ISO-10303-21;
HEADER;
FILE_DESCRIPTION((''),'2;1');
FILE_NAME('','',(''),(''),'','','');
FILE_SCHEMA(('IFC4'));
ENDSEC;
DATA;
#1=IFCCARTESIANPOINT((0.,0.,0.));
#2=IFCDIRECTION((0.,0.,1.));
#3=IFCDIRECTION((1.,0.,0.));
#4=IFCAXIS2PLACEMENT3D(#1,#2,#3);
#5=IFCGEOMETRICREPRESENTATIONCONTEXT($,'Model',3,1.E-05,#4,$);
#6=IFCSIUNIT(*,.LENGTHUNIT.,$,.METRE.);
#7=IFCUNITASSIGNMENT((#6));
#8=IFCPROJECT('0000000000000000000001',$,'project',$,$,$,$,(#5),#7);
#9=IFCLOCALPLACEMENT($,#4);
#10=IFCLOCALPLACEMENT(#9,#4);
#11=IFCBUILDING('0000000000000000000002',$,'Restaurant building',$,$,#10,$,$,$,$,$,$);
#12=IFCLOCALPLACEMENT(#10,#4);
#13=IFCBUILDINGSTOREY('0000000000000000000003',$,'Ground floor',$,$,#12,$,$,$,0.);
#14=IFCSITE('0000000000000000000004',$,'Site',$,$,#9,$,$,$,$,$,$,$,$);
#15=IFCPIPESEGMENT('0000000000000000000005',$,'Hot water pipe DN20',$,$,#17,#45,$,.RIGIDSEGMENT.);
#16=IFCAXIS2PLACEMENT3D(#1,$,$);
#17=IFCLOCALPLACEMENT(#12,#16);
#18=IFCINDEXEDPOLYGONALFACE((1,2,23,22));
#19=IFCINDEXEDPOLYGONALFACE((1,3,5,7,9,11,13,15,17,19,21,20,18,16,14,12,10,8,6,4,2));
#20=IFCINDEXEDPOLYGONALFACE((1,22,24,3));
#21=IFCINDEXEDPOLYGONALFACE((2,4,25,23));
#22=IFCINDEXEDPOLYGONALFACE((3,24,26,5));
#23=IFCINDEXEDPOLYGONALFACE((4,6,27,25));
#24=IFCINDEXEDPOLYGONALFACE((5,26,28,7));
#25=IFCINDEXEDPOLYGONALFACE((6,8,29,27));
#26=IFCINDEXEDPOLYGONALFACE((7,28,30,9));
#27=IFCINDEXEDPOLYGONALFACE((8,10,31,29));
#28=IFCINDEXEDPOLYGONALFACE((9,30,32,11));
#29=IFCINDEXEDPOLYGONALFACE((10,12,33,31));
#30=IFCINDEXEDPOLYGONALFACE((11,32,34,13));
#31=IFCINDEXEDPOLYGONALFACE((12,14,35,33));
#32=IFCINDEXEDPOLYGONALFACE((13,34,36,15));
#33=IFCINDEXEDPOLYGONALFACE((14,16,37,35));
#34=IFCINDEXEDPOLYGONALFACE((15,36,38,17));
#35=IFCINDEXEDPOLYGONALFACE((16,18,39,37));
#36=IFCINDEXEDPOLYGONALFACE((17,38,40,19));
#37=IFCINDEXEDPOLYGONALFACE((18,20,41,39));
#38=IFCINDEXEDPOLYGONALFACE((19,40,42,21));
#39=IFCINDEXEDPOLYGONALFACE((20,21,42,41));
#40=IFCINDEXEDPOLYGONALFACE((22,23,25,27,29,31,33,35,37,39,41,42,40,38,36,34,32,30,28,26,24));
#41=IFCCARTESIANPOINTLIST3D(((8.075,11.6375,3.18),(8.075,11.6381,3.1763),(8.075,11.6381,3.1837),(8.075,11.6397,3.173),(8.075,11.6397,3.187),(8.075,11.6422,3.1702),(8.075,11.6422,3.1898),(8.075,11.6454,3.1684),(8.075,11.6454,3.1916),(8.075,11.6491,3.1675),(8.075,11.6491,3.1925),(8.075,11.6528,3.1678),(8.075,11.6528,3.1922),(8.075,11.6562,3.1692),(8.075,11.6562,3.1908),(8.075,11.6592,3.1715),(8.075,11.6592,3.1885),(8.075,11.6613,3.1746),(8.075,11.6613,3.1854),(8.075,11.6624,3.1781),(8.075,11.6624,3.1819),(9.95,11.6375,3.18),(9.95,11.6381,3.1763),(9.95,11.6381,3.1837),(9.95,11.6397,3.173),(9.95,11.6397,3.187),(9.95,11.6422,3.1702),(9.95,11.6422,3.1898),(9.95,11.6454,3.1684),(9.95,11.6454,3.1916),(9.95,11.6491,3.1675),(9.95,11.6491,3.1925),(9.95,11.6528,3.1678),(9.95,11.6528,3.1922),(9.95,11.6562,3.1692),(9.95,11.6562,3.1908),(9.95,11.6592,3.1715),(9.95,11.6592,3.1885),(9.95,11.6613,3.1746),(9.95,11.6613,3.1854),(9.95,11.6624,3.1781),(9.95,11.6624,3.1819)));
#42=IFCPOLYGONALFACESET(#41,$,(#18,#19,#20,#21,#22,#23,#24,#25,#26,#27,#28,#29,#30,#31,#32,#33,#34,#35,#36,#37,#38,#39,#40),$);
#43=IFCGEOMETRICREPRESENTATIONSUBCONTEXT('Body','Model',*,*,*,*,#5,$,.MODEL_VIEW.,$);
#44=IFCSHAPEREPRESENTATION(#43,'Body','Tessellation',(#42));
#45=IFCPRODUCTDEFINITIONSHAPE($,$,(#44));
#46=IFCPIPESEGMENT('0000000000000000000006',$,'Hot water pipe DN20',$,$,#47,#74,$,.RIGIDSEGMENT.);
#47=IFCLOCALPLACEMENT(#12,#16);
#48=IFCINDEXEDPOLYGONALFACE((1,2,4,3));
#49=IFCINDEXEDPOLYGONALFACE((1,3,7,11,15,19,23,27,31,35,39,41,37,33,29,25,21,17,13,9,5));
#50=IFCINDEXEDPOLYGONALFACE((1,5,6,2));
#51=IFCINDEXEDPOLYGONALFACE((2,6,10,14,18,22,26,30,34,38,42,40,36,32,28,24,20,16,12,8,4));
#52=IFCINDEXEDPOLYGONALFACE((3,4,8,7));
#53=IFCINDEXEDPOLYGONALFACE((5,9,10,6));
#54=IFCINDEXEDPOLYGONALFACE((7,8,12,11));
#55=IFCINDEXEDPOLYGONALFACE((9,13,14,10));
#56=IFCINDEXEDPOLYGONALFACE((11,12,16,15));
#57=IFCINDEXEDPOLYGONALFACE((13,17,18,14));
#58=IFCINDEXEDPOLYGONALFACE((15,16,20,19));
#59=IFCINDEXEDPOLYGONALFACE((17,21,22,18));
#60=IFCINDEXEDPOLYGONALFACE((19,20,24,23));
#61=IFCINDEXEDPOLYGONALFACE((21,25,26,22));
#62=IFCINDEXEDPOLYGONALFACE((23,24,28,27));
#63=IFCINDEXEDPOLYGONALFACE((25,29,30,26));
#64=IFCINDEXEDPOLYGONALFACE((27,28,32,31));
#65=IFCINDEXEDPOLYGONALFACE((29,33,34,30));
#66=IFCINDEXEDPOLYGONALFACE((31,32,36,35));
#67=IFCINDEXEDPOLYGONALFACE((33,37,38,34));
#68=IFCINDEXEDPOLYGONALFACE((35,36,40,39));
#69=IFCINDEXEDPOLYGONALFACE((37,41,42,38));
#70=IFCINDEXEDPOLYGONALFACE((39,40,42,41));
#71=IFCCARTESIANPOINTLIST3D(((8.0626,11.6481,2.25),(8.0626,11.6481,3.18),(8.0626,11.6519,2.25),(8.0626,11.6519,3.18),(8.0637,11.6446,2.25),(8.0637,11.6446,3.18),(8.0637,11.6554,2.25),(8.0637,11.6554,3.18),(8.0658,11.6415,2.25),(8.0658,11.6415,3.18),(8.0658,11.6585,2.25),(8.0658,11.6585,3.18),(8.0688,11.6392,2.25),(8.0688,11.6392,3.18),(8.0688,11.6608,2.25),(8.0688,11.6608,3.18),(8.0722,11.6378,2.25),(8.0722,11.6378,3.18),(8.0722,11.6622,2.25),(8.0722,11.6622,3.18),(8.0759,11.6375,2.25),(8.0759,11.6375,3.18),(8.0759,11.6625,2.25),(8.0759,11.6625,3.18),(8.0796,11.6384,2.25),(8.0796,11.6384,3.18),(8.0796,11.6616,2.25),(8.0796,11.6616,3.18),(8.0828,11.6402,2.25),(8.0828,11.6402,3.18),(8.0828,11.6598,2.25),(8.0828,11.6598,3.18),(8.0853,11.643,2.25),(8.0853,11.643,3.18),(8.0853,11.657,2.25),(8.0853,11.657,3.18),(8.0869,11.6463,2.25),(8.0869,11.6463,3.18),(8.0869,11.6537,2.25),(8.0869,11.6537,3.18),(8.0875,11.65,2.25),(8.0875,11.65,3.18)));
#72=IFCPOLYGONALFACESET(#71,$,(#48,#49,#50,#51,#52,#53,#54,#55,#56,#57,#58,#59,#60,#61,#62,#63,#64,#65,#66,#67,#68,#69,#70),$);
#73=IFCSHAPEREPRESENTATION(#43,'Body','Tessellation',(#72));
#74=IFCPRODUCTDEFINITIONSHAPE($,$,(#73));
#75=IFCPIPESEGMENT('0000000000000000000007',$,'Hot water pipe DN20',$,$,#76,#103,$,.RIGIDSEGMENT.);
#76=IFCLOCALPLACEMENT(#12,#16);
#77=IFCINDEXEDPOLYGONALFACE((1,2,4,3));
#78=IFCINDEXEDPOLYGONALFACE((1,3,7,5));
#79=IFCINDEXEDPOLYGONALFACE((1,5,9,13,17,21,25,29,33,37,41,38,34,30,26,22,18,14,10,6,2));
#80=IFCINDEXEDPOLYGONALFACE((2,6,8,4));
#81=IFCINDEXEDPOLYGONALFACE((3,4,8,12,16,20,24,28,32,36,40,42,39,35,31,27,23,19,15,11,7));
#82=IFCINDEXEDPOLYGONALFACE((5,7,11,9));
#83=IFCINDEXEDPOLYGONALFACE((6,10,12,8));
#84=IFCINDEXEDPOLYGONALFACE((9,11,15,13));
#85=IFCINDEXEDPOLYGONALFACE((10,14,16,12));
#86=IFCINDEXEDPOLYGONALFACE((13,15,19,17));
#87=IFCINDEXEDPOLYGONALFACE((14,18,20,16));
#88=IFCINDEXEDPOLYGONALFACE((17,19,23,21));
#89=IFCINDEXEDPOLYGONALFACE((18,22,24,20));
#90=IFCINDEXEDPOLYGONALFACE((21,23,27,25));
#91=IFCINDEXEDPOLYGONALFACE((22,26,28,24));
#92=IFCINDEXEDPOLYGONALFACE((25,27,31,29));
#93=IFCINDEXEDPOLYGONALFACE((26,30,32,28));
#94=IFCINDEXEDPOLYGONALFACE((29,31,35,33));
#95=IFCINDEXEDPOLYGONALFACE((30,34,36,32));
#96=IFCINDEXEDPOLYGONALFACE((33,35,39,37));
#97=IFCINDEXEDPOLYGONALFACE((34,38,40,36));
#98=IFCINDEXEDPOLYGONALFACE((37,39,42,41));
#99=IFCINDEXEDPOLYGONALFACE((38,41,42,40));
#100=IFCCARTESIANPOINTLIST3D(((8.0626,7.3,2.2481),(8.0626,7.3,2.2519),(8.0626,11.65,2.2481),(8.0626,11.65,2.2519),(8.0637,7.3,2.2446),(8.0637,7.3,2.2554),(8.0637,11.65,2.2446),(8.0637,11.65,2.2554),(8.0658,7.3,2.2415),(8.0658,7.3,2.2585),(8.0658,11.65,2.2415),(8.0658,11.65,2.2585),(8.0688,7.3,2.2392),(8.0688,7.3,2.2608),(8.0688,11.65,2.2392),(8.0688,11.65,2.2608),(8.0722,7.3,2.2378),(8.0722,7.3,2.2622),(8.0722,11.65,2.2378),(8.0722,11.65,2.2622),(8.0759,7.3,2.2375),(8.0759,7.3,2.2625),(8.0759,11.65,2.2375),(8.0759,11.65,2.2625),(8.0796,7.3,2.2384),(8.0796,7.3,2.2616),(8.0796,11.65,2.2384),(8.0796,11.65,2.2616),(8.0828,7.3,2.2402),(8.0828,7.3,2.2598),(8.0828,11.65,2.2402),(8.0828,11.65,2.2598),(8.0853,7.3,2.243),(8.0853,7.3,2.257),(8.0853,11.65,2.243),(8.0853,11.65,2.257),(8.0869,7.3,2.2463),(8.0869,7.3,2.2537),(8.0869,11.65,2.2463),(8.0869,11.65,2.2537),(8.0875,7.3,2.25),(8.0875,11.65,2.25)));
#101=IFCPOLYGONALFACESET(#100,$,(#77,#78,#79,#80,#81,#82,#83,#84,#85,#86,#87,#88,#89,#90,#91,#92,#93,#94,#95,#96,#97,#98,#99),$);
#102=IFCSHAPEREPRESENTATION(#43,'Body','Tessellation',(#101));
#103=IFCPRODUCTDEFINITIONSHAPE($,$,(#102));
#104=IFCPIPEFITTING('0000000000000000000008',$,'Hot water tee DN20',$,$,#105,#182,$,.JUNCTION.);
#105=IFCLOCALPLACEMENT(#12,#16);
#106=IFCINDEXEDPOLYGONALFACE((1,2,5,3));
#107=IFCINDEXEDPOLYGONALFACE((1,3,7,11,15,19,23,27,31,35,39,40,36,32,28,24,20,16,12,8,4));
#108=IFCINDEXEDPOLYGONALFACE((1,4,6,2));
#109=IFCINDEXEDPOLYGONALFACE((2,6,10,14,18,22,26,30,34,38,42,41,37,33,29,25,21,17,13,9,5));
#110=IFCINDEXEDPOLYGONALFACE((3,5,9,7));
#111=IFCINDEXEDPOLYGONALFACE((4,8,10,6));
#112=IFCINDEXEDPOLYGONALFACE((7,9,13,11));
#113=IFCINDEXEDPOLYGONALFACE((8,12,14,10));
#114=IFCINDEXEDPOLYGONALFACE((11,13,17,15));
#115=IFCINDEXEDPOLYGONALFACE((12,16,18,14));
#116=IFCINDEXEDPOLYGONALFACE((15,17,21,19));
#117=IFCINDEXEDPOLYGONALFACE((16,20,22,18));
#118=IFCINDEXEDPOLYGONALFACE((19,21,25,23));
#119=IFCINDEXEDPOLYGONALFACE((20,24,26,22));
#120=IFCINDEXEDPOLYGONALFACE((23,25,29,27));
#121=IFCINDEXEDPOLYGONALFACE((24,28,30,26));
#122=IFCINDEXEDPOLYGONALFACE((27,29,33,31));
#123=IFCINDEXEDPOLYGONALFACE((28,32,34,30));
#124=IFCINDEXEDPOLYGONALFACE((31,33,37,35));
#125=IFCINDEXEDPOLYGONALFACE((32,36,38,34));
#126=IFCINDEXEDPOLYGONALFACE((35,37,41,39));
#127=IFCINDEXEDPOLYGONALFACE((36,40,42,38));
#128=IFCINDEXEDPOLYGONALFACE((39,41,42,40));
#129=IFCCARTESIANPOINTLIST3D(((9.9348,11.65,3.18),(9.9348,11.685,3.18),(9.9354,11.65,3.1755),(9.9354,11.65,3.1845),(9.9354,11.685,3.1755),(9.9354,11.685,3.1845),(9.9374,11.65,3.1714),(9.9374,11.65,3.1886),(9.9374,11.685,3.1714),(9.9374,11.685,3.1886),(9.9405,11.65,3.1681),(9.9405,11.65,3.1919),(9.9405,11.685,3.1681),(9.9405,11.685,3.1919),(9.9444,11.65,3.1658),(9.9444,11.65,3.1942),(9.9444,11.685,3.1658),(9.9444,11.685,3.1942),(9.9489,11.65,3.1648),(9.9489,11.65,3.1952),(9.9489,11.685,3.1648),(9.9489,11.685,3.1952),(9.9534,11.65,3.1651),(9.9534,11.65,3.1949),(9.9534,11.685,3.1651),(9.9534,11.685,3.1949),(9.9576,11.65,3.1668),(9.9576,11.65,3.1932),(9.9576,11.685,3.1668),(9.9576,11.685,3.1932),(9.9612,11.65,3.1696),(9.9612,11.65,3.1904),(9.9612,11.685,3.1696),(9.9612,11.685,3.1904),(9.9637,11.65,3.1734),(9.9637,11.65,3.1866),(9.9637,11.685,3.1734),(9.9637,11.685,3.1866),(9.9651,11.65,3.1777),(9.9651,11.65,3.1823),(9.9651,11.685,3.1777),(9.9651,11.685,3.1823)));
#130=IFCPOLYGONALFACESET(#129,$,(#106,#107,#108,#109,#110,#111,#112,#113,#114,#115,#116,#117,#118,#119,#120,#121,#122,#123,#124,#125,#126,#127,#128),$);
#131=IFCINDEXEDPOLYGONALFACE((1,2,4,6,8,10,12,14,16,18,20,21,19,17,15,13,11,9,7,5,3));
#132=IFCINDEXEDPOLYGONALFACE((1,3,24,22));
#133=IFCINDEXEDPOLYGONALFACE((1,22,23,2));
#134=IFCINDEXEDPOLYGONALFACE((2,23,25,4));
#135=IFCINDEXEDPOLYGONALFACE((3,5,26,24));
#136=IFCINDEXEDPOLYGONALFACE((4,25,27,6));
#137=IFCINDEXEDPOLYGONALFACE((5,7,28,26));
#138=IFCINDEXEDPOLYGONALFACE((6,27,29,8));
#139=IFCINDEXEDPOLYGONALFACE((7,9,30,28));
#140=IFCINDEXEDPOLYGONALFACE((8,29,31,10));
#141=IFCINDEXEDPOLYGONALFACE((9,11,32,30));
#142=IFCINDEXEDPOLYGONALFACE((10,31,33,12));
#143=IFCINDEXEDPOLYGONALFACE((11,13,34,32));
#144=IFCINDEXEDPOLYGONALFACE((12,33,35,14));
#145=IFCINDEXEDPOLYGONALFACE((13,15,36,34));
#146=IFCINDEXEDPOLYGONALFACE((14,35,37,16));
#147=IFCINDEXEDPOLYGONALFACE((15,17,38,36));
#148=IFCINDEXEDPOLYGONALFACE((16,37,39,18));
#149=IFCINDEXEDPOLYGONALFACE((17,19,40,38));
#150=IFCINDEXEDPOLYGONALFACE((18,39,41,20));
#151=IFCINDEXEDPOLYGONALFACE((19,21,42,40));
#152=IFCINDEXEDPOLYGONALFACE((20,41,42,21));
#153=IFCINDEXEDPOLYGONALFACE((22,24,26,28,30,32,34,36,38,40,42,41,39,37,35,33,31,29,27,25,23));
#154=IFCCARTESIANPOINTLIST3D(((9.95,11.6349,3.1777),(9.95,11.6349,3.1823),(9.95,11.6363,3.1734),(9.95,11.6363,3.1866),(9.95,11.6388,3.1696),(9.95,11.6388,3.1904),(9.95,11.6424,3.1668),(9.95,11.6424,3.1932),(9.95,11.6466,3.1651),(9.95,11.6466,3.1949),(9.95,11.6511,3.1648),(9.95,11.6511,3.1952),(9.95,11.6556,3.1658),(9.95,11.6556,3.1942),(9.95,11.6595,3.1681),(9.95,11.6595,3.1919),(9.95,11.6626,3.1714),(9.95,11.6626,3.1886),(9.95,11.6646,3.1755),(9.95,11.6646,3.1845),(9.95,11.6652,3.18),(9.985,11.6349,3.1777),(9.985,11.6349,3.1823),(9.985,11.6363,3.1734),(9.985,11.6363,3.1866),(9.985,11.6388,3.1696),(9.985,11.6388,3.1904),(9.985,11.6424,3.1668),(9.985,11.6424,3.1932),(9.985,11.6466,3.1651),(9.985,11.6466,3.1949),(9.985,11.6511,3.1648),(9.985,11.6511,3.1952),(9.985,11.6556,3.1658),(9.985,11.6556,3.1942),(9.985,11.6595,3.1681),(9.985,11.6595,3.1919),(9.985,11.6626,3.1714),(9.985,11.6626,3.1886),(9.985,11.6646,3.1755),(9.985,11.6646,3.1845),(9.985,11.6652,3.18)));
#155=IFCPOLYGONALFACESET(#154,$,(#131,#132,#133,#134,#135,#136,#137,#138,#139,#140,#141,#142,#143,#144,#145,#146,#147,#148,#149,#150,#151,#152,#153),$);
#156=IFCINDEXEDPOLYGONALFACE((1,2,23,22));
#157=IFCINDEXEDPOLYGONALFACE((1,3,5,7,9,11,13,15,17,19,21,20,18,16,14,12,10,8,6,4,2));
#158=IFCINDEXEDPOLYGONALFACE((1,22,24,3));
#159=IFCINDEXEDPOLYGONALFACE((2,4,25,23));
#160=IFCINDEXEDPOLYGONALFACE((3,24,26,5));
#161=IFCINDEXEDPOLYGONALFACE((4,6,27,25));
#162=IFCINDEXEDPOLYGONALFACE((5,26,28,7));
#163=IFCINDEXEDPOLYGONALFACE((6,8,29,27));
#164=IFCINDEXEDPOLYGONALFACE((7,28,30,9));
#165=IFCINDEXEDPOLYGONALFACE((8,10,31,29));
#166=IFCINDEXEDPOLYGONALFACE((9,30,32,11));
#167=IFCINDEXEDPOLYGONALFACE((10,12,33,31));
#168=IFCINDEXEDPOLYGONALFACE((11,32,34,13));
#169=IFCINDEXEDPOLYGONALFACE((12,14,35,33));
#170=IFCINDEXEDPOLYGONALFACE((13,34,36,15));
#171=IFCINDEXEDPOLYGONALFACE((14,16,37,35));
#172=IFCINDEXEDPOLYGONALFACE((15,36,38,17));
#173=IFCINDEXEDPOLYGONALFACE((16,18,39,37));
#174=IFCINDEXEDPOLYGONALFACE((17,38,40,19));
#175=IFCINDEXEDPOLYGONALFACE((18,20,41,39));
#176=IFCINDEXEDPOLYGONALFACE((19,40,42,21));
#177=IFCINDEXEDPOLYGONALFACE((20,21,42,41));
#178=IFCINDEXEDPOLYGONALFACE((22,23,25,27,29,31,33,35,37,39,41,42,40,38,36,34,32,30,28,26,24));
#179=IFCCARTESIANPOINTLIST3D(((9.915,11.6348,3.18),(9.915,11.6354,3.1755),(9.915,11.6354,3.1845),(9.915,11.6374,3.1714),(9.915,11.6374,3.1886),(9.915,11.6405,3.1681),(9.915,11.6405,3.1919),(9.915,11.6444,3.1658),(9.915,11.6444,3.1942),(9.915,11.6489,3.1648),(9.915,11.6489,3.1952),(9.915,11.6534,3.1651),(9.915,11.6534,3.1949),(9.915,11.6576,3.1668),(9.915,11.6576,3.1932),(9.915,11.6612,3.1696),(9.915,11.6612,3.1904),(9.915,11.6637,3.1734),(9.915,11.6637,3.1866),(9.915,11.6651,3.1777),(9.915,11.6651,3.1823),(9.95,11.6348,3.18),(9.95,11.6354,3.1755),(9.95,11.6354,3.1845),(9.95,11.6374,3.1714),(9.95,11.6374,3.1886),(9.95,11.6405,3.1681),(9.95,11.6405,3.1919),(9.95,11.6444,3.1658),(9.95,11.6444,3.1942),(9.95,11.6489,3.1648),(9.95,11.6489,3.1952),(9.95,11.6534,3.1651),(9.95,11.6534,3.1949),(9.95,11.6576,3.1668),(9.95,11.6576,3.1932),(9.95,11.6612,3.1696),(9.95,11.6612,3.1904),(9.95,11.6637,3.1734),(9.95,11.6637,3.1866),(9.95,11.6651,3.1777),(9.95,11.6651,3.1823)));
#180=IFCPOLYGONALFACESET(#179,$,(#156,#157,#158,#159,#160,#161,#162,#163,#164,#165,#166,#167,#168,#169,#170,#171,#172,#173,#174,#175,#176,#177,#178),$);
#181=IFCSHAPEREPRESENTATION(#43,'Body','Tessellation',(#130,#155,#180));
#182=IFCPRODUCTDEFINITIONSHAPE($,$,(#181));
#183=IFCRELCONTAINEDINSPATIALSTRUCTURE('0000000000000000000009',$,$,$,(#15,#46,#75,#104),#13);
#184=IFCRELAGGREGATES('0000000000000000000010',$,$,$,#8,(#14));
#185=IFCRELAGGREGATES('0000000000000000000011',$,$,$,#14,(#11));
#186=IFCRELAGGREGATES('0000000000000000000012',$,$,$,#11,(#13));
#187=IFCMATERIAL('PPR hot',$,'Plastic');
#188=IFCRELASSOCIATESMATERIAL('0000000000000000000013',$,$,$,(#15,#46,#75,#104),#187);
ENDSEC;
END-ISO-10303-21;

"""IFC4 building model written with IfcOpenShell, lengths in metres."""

from ifc_helpers import new_model, si_unit, frame, origin_with_axes, origin_2d, place, context, subcontext, project, spatial, circle, extrude, material, element, save


model = new_model("IFC4")

# Units and contexts
model_context = context("Model", 3, precision=1e-05, world=origin_with_axes())
body_context = subcontext(model_context, "Body", "Model", "MODEL_VIEW")
ifc_project = project(units=[si_unit("LENGTHUNIT", "METRE")], contexts=[model_context])

# Site, building, storey
site_placement = place(None, origin_with_axes())
site = spatial("IfcSite", under=ifc_project, at=site_placement, Name="Site")
building_placement = place(site_placement, origin_with_axes())
building = spatial("IfcBuilding", under=site, at=building_placement, Name="Restaurant building")
storey_placement = place(building_placement, origin_with_axes())
storey = spatial("IfcBuildingStorey", under=building, at=storey_placement, Name="Ground floor", Elevation=0.0)

# Pipe segments
ifc_material_1 = material(Name="PPR hot", Category="Plastic")
pipe_segment_1_placement = place(storey_placement, frame((9.95, 11.65, 3.18)))
element("IfcPipeSegment", 1, at=pipe_segment_1_placement, inside=storey, material=ifc_material_1, Name="Hot water pipe DN20", PredefinedType="RIGIDSEGMENT", context=body_context, shape_type="SweptSolid", body=[
    extrude(circle(Radius=0.0125, at=origin_2d()), frame((0.0, 0.0, 0.0), z_axis=(-1.0, 0.0, 0.0), x_axis=(0.0, -1.0, 0.0)), (0.0, 0.0, 1.0), 1.875),
])
pipe_segment_2_placement = place(storey_placement, frame((8.075, 11.65, 3.18)))
element("IfcPipeSegment", 2, at=pipe_segment_2_placement, inside=storey, material=ifc_material_1, Name="Hot water pipe DN20", PredefinedType="RIGIDSEGMENT", context=body_context, shape_type="SweptSolid", body=[
    extrude(circle(Radius=0.0125, at=origin_2d()), frame((0.0, 0.0, 0.0), z_axis=(0.0, 0.0, -1.0), x_axis=(1.0, 0.0, 0.0)), (0.0, 0.0, 1.0), 0.93),
])
pipe_segment_3_placement = place(storey_placement, frame((8.075, 11.65, 2.25)))
element("IfcPipeSegment", 3, at=pipe_segment_3_placement, inside=storey, material=ifc_material_1, Name="Hot water pipe DN20", PredefinedType="RIGIDSEGMENT", context=body_context, shape_type="SweptSolid", body=[
    extrude(circle(Radius=0.0125, at=origin_2d()), frame((0.0, 0.0, 0.0), z_axis=(0.0, -1.0, 0.0), x_axis=(1.0, 0.0, 0.0)), (0.0, 0.0, 1.0), 4.35),
])

# Pipe fitting
pipe_fitting_1_placement = place(storey_placement, frame((9.95, 11.65, 3.18)))
element("IfcPipeFitting", 4, at=pipe_fitting_1_placement, inside=storey, material=ifc_material_1, Name="Hot water tee DN20", PredefinedType="JUNCTION", context=body_context, shape_type="SweptSolid", body=[
    extrude(circle(Radius=0.0152, at=origin_2d()), frame((0.0, 0.0, 0.0), z_axis=(0.0, 1.0, 0.0), x_axis=(-1.0, 0.0, 0.0)), (0.0, 0.0, 1.0), 0.035),
    extrude(circle(Radius=0.0152, at=origin_2d()), frame((0.0, 0.0, 0.0), z_axis=(1.0, 0.0, 0.0), x_axis=(0.0, 1.0, 0.0)), (0.0, 0.0, 1.0), 0.035),
    extrude(circle(Radius=0.0152, at=origin_2d()), frame((0.0, 0.0, 0.0), z_axis=(-1.0, 0.0, 0.0), x_axis=(0.0, -1.0, 0.0)), (0.0, 0.0, 1.0), 0.035),
])

save(model, "model.ifc")
